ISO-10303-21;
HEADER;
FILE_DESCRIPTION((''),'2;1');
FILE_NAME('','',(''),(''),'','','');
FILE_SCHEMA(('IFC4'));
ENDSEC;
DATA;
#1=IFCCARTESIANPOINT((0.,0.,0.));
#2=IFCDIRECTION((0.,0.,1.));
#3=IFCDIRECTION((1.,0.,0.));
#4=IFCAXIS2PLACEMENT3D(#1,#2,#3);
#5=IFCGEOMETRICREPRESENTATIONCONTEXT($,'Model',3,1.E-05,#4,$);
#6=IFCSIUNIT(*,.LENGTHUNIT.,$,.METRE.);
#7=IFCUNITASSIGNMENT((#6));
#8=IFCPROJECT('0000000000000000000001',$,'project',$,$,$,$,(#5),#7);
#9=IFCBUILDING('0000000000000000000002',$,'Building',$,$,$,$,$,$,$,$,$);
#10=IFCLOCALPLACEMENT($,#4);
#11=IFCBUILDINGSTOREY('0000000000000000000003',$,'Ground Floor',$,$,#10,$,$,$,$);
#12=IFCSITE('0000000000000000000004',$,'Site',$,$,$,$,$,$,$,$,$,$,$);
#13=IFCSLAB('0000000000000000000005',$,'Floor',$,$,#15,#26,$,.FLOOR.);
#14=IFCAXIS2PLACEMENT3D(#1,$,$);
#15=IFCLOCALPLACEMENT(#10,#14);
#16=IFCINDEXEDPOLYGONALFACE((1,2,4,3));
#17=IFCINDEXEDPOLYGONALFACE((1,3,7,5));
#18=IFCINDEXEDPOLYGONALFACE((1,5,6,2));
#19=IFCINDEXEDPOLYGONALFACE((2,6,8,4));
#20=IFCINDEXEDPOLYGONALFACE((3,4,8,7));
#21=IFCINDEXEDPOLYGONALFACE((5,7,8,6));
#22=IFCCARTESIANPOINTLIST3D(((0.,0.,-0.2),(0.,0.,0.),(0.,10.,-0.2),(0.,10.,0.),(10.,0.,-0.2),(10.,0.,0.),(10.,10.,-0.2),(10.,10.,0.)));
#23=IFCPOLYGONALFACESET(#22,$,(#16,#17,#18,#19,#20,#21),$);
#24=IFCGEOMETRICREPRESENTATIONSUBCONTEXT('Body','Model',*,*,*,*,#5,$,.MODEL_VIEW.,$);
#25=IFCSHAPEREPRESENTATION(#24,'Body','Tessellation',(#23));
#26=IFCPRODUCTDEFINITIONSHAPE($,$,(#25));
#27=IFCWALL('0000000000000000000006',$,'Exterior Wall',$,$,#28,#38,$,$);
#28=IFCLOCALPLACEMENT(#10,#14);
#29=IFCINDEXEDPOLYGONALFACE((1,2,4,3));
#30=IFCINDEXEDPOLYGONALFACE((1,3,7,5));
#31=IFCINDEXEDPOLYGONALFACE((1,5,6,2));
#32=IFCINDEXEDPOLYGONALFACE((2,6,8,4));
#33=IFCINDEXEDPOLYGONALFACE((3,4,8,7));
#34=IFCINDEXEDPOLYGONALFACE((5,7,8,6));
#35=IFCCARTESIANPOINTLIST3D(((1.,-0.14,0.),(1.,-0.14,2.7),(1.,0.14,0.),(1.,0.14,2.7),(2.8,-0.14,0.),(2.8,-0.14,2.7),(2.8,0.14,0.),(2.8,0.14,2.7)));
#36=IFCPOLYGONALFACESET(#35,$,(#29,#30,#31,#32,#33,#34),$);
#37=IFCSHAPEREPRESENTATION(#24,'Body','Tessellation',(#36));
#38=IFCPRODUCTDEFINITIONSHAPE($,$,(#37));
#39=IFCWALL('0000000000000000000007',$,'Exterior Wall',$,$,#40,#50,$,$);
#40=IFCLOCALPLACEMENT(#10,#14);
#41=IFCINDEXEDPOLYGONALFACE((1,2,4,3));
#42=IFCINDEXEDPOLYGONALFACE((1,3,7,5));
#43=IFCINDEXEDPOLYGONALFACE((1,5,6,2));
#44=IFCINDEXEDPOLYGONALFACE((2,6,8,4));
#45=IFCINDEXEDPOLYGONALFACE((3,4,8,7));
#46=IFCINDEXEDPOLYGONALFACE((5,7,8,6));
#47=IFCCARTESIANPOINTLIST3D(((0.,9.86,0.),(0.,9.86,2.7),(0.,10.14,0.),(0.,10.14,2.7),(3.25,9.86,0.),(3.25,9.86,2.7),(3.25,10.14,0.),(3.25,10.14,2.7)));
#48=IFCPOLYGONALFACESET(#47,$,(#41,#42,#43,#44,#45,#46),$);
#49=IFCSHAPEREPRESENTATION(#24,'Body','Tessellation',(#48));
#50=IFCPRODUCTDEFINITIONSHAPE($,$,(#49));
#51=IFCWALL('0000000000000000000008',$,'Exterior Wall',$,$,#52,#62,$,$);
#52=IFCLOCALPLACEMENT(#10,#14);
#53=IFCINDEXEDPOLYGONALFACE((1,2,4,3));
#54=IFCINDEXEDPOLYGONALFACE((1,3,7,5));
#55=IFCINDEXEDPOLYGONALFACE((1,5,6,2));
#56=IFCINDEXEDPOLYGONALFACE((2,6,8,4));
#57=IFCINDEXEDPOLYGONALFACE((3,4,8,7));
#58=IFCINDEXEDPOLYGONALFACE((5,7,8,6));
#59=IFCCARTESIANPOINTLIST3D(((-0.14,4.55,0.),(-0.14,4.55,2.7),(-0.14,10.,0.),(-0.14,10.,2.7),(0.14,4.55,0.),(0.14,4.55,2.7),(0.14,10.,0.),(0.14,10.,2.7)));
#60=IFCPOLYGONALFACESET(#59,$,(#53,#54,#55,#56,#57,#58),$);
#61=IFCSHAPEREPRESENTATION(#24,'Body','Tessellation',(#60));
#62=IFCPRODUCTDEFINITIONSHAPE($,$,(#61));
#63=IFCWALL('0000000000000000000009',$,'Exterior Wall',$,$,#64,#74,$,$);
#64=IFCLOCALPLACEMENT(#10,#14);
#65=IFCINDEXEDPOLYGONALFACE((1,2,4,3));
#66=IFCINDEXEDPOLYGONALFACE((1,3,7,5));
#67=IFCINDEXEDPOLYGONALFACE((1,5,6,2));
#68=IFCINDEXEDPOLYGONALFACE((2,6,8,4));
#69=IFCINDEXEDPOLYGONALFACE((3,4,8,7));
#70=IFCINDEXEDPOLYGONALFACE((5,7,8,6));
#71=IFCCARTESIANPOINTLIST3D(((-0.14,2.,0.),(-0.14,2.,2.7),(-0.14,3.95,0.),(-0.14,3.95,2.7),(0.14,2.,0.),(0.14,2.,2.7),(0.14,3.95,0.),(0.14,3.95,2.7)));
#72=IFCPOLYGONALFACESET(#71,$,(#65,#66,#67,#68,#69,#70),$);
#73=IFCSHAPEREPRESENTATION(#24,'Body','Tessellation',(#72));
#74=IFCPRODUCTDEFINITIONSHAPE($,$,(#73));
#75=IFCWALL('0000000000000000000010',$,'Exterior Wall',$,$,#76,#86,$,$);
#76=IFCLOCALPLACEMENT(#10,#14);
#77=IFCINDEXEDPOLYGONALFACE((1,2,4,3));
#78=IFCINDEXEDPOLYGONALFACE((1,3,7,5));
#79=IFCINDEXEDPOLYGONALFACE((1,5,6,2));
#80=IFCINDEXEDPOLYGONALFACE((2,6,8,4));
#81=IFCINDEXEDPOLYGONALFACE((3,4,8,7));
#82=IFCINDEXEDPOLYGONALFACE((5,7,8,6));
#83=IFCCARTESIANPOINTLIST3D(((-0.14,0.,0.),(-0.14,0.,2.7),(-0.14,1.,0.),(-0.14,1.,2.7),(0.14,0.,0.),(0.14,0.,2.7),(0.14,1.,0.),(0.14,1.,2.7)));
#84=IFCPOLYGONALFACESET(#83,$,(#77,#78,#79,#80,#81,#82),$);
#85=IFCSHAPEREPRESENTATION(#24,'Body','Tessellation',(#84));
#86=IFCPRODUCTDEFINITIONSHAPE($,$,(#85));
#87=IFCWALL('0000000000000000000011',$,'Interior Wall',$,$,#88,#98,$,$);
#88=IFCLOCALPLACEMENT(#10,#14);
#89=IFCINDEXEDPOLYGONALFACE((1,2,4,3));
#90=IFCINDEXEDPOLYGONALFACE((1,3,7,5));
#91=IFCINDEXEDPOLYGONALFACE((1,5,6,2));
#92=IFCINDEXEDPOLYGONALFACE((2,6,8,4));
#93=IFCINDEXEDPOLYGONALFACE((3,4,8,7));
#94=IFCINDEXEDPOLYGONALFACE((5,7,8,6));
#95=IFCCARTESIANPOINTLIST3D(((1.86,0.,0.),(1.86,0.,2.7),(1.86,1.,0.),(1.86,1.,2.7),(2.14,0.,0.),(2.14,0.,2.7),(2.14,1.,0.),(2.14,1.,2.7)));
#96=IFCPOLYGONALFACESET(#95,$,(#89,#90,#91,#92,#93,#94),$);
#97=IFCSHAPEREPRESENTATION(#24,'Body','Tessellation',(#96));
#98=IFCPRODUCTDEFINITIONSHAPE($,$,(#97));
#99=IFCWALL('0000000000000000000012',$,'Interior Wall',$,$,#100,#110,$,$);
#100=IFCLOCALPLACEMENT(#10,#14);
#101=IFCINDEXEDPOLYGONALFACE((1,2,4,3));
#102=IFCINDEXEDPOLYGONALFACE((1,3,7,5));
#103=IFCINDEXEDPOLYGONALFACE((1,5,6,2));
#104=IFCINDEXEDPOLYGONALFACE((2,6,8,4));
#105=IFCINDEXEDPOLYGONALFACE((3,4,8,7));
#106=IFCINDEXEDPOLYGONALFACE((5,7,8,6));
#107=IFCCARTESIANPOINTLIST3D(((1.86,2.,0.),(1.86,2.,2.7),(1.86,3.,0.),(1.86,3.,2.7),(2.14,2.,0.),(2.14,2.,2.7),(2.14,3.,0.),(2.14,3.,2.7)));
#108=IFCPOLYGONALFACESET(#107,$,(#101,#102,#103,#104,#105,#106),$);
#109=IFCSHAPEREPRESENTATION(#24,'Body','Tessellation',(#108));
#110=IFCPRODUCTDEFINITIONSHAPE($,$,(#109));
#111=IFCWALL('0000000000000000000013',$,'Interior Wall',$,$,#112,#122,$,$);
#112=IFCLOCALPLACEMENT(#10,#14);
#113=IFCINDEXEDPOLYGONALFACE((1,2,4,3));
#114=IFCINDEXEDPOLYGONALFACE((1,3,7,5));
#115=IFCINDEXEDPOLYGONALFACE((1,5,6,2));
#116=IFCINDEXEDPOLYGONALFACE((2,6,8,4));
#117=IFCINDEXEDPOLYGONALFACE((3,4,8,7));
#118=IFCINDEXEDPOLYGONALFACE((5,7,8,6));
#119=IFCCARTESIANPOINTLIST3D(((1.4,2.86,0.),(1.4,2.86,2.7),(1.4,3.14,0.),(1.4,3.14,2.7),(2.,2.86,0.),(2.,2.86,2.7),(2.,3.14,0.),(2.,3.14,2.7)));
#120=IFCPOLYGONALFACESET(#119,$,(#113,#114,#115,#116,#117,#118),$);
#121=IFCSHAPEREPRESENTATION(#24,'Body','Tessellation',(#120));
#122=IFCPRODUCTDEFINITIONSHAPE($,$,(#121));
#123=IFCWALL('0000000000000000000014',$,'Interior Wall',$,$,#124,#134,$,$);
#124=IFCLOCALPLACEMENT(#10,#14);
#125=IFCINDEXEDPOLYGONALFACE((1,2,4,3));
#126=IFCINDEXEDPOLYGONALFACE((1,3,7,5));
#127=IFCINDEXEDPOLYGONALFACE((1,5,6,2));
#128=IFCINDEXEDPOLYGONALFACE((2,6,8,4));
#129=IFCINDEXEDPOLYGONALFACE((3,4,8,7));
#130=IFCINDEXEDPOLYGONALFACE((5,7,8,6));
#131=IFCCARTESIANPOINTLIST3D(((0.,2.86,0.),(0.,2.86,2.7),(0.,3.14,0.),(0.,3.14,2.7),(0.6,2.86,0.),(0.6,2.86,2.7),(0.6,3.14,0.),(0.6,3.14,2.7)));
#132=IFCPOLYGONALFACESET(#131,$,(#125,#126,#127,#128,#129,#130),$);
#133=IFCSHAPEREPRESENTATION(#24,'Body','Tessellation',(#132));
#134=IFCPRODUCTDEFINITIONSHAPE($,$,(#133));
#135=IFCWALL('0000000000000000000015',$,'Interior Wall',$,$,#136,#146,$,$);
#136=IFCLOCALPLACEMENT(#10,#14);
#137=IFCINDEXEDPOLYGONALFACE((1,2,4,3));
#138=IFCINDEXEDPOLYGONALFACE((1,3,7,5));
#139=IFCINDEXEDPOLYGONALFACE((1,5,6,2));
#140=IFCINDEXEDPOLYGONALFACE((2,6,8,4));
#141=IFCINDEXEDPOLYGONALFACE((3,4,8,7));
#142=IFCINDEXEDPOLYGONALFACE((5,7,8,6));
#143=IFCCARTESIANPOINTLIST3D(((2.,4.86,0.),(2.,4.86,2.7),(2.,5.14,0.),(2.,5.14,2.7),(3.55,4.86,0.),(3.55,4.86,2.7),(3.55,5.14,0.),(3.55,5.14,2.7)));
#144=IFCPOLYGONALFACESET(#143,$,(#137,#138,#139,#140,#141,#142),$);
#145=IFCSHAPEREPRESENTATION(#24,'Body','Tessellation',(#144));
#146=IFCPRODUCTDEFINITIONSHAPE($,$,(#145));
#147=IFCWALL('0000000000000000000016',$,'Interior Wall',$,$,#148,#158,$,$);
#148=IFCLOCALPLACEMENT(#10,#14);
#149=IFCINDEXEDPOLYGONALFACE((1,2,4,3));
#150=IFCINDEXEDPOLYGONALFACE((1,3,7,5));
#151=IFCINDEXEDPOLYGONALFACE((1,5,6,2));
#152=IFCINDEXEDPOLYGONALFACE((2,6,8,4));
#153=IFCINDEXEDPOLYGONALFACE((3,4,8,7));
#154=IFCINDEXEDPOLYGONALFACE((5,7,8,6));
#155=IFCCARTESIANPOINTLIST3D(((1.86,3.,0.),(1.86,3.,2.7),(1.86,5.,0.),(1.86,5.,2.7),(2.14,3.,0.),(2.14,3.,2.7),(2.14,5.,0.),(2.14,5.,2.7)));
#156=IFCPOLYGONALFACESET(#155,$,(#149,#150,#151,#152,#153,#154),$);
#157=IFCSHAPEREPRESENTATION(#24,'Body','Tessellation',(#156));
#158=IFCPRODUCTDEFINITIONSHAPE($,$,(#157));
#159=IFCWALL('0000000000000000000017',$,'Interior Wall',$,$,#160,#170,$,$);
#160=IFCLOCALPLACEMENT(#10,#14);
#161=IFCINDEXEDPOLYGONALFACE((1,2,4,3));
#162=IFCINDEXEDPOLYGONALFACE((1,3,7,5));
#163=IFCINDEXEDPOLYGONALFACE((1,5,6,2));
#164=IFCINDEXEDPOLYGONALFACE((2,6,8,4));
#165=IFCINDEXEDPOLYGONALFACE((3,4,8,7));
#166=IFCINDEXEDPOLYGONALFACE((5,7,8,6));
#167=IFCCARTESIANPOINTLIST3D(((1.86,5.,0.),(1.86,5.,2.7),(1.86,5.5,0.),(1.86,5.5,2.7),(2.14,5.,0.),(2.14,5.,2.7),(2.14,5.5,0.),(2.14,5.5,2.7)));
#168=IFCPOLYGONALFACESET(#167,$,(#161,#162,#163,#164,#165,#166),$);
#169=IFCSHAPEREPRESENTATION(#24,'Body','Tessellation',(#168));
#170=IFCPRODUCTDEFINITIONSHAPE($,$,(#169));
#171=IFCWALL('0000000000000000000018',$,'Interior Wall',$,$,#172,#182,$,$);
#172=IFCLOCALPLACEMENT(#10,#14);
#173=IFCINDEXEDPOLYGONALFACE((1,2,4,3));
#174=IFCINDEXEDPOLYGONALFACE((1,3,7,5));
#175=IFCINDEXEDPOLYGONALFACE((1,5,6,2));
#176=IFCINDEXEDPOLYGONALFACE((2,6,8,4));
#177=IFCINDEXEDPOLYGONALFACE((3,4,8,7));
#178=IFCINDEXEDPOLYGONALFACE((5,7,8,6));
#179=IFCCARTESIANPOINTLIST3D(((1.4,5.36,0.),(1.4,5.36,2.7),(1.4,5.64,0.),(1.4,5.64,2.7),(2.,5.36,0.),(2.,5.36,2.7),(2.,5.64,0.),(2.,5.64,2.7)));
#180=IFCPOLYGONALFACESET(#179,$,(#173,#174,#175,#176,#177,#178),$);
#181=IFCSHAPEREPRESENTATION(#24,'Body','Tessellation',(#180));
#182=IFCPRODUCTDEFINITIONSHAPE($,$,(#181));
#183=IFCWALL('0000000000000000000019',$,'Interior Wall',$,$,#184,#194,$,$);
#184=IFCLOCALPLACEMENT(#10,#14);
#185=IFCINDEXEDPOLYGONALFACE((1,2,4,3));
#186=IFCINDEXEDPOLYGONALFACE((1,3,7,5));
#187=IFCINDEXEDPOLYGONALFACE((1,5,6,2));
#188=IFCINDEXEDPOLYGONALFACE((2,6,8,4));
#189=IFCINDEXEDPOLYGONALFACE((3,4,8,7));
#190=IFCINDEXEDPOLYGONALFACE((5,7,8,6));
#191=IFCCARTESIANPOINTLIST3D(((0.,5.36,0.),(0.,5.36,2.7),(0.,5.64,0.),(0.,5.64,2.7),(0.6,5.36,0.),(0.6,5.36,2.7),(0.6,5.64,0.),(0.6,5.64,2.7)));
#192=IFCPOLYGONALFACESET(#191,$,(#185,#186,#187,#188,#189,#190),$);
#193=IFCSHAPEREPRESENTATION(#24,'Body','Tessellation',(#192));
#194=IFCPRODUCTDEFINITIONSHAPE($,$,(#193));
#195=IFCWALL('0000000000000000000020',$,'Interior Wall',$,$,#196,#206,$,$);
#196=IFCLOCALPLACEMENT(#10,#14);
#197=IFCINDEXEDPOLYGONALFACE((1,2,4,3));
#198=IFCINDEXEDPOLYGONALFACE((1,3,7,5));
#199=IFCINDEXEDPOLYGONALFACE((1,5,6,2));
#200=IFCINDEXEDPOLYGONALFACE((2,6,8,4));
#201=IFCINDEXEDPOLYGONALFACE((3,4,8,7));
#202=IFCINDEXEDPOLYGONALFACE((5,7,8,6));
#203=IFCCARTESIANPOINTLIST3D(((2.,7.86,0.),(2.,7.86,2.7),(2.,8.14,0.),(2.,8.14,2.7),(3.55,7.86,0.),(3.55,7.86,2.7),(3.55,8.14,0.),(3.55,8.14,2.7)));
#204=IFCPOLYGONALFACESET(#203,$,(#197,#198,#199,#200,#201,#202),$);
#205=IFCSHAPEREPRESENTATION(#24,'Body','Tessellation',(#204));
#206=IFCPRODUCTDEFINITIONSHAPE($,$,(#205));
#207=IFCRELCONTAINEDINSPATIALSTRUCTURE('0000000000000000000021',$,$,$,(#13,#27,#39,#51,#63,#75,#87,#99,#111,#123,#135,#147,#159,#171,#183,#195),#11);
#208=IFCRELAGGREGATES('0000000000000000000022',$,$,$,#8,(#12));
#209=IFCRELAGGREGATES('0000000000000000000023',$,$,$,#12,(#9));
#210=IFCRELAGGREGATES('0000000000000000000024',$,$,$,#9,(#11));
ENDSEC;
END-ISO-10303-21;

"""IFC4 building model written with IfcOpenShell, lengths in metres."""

from ifc_helpers import new_model, si_unit, frame, origin_with_axes, place, context, subcontext, project, spatial, indexed_curve, outline, extrude, element, save


model = new_model("IFC4")

# Units and contexts
model_context = context("Model", 3, precision=1e-05, world=origin_with_axes())
body_context = subcontext(model_context, "Body", "Model", "MODEL_VIEW")
ifc_project = project(units=[si_unit("LENGTHUNIT", "METRE")], contexts=[model_context])

# Site, building, storey
site = spatial("IfcSite", under=ifc_project, Name="Site")
building = spatial("IfcBuilding", under=site, Name="Building")
storey_placement = place(None, origin_with_axes())
storey = spatial("IfcBuildingStorey", under=building, at=storey_placement, Name="Ground Floor")

# Slab
slab_placement = place(storey_placement, frame((0.0, 0.0, -0.2), z_axis=(0.0, 0.0, 1.0), x_axis=(1.0, 0.0, 0.0)))
element("IfcSlab", 1, at=slab_placement, inside=storey, Name="Floor", PredefinedType="FLOOR", context=body_context, shape_type="SweptSolid", body=[
    extrude(outline(indexed_curve([(0.0, 0.0), (10.0, 0.0), (10.0, 10.0), (0.0, 10.0)])), None, (0.0, 0.0, 1.0), 0.2),
])

# Walls
wall_1_placement = place(storey_placement, frame((1.0, 0.0, 0.0), z_axis=(0.0, 0.0, 1.0), x_axis=(1.0, 0.0, 0.0)))
element("IfcWall", 2, at=wall_1_placement, inside=storey, Name="Exterior Wall", context=body_context, shape_type="SweptSolid", body=[
    extrude(outline(indexed_curve([(0.0, 0.0), (0.0, 0.28), (1.8, 0.28), (1.8, 0.0), (0.0, 0.0)], self_intersect=False)), frame((0.0, -0.14, 0.0), z_axis=(0.0, 0.0, 1.0), x_axis=(1.0, 0.0, 0.0)), (0.0, 0.0, 1.0), 2.7),
])
wall_2_placement = place(storey_placement, frame((3.25, 10.0, 0.0), z_axis=(0.0, 0.0, 1.0), x_axis=(-1.0, 0.0, 0.0)))
element("IfcWall", 3, at=wall_2_placement, inside=storey, Name="Exterior Wall", context=body_context, shape_type="SweptSolid", body=[
    extrude(outline(indexed_curve([(0.0, 0.0), (0.0, 0.28), (3.25, 0.28), (3.25, 0.0), (0.0, 0.0)], self_intersect=False)), frame((0.0, -0.14, 0.0), z_axis=(0.0, 0.0, 1.0), x_axis=(1.0, 0.0, 0.0)), (0.0, 0.0, 1.0), 2.7),
])
wall_3_placement = place(storey_placement, frame((0.0, 10.0, 0.0), z_axis=(0.0, 0.0, 1.0), x_axis=(0.0, -1.0, 0.0)))
element("IfcWall", 4, at=wall_3_placement, inside=storey, Name="Exterior Wall", context=body_context, shape_type="SweptSolid", body=[
    extrude(outline(indexed_curve([(0.0, 0.0), (0.0, 0.28), (5.45, 0.28), (5.45, 0.0), (0.0, 0.0)], self_intersect=False)), frame((0.0, -0.14, 0.0), z_axis=(0.0, 0.0, 1.0), x_axis=(1.0, 0.0, 0.0)), (0.0, 0.0, 1.0), 2.7),
])
wall_4_placement = place(storey_placement, frame((0.0, 3.95, 0.0), z_axis=(0.0, 0.0, 1.0), x_axis=(0.0, -1.0, 0.0)))
element("IfcWall", 5, at=wall_4_placement, inside=storey, Name="Exterior Wall", context=body_context, shape_type="SweptSolid", body=[
    extrude(outline(indexed_curve([(0.0, 0.0), (0.0, 0.28), (1.95, 0.28), (1.95, 0.0), (0.0, 0.0)], self_intersect=False)), frame((0.0, -0.14, 0.0), z_axis=(0.0, 0.0, 1.0), x_axis=(1.0, 0.0, 0.0)), (0.0, 0.0, 1.0), 2.7),
])
for number, where, z_axis, x_axis, name in (
    (6, (0.0, 1.0, 0.0), (0.0, 0.0, 1.0), (0.0, -1.0, 0.0), "Exterior Wall"),
    (7, (2.0, 0.0, 0.0), (0.0, 0.0, 1.0), (0.0, 1.0, 0.0), "Interior Wall"),
    (8, (2.0, 2.0, 0.0), (0.0, 0.0, 1.0), (0.0, 1.0, 0.0), "Interior Wall"),
):
    element("IfcWall", number, at=place(storey_placement, frame(where, z_axis=z_axis, x_axis=x_axis)), inside=storey, Name=name, context=body_context, shape_type="SweptSolid", body=[
        extrude(outline(indexed_curve([(0.0, 0.0), (0.0, 0.28), (1.0, 0.28), (1.0, 0.0), (0.0, 0.0)], self_intersect=False)), frame((0.0, -0.14, 0.0), z_axis=(0.0, 0.0, 1.0), x_axis=(1.0, 0.0, 0.0)), (0.0, 0.0, 1.0), 2.7),
    ])
for number, where, z_axis, x_axis, name in (
    (9, (2.0, 3.0, 0.0), (0.0, 0.0, 1.0), (-1.0, 0.0, 0.0), "Interior Wall"),
    (10, (0.6, 3.0, 0.0), (0.0, 0.0, 1.0), (-1.0, 0.0, 0.0), "Interior Wall"),
):
    element("IfcWall", number, at=place(storey_placement, frame(where, z_axis=z_axis, x_axis=x_axis)), inside=storey, Name=name, context=body_context, shape_type="SweptSolid", body=[
        extrude(outline(indexed_curve([(0.0, 0.0), (0.0, 0.28), (0.6, 0.28), (0.6, 0.0), (0.0, 0.0)], self_intersect=False)), frame((0.0, -0.14, 0.0), z_axis=(0.0, 0.0, 1.0), x_axis=(1.0, 0.0, 0.0)), (0.0, 0.0, 1.0), 2.7),
    ])
wall_5_placement = place(storey_placement, frame((3.55, 5.0, 0.0), z_axis=(0.0, 0.0, 1.0), x_axis=(-1.0, 0.0, 0.0)))
element("IfcWall", 11, at=wall_5_placement, inside=storey, Name="Interior Wall", context=body_context, shape_type="SweptSolid", body=[
    extrude(outline(indexed_curve([(0.0, 0.0), (0.0, 0.28), (1.55, 0.28), (1.55, 0.0), (0.0, 0.0)], self_intersect=False)), frame((0.0, -0.14, 0.0), z_axis=(0.0, 0.0, 1.0), x_axis=(1.0, 0.0, 0.0)), (0.0, 0.0, 1.0), 2.7),
])
wall_6_placement = place(storey_placement, frame((2.0, 5.0, 0.0), z_axis=(0.0, 0.0, 1.0), x_axis=(0.0, -1.0, 0.0)))
element("IfcWall", 12, at=wall_6_placement, inside=storey, Name="Interior Wall", context=body_context, shape_type="SweptSolid", body=[
    extrude(outline(indexed_curve([(0.0, 0.0), (0.0, 0.28), (2.0, 0.28), (2.0, 0.0), (0.0, 0.0)], self_intersect=False)), frame((0.0, -0.14, 0.0), z_axis=(0.0, 0.0, 1.0), x_axis=(1.0, 0.0, 0.0)), (0.0, 0.0, 1.0), 2.7),
])
wall_7_placement = place(storey_placement, frame((2.0, 5.0, 0.0), z_axis=(0.0, 0.0, 1.0), x_axis=(0.0, 1.0, 0.0)))
element("IfcWall", 13, at=wall_7_placement, inside=storey, Name="Interior Wall", context=body_context, shape_type="SweptSolid", body=[
    extrude(outline(indexed_curve([(0.0, 0.0), (0.0, 0.28), (0.5, 0.28), (0.5, 0.0), (0.0, 0.0)], self_intersect=False)), frame((0.0, -0.14, 0.0), z_axis=(0.0, 0.0, 1.0), x_axis=(1.0, 0.0, 0.0)), (0.0, 0.0, 1.0), 2.7),
])
for number, where, z_axis, x_axis, name in (
    (14, (2.0, 5.5, 0.0), (0.0, 0.0, 1.0), (-1.0, 0.0, 0.0), "Interior Wall"),
    (15, (0.6, 5.5, 0.0), (0.0, 0.0, 1.0), (-1.0, 0.0, 0.0), "Interior Wall"),
):
    element("IfcWall", number, at=place(storey_placement, frame(where, z_axis=z_axis, x_axis=x_axis)), inside=storey, Name=name, context=body_context, shape_type="SweptSolid", body=[
        extrude(outline(indexed_curve([(0.0, 0.0), (0.0, 0.28), (0.6, 0.28), (0.6, 0.0), (0.0, 0.0)], self_intersect=False)), frame((0.0, -0.14, 0.0), z_axis=(0.0, 0.0, 1.0), x_axis=(1.0, 0.0, 0.0)), (0.0, 0.0, 1.0), 2.7),
    ])
wall_8_placement = place(storey_placement, frame((3.55, 8.0, 0.0), z_axis=(0.0, 0.0, 1.0), x_axis=(-1.0, 0.0, 0.0)))
element("IfcWall", 16, at=wall_8_placement, inside=storey, Name="Interior Wall", context=body_context, shape_type="SweptSolid", body=[
    extrude(outline(indexed_curve([(0.0, 0.0), (0.0, 0.28), (1.55, 0.28), (1.55, 0.0), (0.0, 0.0)], self_intersect=False)), frame((0.0, -0.14, 0.0), z_axis=(0.0, 0.0, 1.0), x_axis=(1.0, 0.0, 0.0)), (0.0, 0.0, 1.0), 2.7),
])

save(model, "model.ifc")
